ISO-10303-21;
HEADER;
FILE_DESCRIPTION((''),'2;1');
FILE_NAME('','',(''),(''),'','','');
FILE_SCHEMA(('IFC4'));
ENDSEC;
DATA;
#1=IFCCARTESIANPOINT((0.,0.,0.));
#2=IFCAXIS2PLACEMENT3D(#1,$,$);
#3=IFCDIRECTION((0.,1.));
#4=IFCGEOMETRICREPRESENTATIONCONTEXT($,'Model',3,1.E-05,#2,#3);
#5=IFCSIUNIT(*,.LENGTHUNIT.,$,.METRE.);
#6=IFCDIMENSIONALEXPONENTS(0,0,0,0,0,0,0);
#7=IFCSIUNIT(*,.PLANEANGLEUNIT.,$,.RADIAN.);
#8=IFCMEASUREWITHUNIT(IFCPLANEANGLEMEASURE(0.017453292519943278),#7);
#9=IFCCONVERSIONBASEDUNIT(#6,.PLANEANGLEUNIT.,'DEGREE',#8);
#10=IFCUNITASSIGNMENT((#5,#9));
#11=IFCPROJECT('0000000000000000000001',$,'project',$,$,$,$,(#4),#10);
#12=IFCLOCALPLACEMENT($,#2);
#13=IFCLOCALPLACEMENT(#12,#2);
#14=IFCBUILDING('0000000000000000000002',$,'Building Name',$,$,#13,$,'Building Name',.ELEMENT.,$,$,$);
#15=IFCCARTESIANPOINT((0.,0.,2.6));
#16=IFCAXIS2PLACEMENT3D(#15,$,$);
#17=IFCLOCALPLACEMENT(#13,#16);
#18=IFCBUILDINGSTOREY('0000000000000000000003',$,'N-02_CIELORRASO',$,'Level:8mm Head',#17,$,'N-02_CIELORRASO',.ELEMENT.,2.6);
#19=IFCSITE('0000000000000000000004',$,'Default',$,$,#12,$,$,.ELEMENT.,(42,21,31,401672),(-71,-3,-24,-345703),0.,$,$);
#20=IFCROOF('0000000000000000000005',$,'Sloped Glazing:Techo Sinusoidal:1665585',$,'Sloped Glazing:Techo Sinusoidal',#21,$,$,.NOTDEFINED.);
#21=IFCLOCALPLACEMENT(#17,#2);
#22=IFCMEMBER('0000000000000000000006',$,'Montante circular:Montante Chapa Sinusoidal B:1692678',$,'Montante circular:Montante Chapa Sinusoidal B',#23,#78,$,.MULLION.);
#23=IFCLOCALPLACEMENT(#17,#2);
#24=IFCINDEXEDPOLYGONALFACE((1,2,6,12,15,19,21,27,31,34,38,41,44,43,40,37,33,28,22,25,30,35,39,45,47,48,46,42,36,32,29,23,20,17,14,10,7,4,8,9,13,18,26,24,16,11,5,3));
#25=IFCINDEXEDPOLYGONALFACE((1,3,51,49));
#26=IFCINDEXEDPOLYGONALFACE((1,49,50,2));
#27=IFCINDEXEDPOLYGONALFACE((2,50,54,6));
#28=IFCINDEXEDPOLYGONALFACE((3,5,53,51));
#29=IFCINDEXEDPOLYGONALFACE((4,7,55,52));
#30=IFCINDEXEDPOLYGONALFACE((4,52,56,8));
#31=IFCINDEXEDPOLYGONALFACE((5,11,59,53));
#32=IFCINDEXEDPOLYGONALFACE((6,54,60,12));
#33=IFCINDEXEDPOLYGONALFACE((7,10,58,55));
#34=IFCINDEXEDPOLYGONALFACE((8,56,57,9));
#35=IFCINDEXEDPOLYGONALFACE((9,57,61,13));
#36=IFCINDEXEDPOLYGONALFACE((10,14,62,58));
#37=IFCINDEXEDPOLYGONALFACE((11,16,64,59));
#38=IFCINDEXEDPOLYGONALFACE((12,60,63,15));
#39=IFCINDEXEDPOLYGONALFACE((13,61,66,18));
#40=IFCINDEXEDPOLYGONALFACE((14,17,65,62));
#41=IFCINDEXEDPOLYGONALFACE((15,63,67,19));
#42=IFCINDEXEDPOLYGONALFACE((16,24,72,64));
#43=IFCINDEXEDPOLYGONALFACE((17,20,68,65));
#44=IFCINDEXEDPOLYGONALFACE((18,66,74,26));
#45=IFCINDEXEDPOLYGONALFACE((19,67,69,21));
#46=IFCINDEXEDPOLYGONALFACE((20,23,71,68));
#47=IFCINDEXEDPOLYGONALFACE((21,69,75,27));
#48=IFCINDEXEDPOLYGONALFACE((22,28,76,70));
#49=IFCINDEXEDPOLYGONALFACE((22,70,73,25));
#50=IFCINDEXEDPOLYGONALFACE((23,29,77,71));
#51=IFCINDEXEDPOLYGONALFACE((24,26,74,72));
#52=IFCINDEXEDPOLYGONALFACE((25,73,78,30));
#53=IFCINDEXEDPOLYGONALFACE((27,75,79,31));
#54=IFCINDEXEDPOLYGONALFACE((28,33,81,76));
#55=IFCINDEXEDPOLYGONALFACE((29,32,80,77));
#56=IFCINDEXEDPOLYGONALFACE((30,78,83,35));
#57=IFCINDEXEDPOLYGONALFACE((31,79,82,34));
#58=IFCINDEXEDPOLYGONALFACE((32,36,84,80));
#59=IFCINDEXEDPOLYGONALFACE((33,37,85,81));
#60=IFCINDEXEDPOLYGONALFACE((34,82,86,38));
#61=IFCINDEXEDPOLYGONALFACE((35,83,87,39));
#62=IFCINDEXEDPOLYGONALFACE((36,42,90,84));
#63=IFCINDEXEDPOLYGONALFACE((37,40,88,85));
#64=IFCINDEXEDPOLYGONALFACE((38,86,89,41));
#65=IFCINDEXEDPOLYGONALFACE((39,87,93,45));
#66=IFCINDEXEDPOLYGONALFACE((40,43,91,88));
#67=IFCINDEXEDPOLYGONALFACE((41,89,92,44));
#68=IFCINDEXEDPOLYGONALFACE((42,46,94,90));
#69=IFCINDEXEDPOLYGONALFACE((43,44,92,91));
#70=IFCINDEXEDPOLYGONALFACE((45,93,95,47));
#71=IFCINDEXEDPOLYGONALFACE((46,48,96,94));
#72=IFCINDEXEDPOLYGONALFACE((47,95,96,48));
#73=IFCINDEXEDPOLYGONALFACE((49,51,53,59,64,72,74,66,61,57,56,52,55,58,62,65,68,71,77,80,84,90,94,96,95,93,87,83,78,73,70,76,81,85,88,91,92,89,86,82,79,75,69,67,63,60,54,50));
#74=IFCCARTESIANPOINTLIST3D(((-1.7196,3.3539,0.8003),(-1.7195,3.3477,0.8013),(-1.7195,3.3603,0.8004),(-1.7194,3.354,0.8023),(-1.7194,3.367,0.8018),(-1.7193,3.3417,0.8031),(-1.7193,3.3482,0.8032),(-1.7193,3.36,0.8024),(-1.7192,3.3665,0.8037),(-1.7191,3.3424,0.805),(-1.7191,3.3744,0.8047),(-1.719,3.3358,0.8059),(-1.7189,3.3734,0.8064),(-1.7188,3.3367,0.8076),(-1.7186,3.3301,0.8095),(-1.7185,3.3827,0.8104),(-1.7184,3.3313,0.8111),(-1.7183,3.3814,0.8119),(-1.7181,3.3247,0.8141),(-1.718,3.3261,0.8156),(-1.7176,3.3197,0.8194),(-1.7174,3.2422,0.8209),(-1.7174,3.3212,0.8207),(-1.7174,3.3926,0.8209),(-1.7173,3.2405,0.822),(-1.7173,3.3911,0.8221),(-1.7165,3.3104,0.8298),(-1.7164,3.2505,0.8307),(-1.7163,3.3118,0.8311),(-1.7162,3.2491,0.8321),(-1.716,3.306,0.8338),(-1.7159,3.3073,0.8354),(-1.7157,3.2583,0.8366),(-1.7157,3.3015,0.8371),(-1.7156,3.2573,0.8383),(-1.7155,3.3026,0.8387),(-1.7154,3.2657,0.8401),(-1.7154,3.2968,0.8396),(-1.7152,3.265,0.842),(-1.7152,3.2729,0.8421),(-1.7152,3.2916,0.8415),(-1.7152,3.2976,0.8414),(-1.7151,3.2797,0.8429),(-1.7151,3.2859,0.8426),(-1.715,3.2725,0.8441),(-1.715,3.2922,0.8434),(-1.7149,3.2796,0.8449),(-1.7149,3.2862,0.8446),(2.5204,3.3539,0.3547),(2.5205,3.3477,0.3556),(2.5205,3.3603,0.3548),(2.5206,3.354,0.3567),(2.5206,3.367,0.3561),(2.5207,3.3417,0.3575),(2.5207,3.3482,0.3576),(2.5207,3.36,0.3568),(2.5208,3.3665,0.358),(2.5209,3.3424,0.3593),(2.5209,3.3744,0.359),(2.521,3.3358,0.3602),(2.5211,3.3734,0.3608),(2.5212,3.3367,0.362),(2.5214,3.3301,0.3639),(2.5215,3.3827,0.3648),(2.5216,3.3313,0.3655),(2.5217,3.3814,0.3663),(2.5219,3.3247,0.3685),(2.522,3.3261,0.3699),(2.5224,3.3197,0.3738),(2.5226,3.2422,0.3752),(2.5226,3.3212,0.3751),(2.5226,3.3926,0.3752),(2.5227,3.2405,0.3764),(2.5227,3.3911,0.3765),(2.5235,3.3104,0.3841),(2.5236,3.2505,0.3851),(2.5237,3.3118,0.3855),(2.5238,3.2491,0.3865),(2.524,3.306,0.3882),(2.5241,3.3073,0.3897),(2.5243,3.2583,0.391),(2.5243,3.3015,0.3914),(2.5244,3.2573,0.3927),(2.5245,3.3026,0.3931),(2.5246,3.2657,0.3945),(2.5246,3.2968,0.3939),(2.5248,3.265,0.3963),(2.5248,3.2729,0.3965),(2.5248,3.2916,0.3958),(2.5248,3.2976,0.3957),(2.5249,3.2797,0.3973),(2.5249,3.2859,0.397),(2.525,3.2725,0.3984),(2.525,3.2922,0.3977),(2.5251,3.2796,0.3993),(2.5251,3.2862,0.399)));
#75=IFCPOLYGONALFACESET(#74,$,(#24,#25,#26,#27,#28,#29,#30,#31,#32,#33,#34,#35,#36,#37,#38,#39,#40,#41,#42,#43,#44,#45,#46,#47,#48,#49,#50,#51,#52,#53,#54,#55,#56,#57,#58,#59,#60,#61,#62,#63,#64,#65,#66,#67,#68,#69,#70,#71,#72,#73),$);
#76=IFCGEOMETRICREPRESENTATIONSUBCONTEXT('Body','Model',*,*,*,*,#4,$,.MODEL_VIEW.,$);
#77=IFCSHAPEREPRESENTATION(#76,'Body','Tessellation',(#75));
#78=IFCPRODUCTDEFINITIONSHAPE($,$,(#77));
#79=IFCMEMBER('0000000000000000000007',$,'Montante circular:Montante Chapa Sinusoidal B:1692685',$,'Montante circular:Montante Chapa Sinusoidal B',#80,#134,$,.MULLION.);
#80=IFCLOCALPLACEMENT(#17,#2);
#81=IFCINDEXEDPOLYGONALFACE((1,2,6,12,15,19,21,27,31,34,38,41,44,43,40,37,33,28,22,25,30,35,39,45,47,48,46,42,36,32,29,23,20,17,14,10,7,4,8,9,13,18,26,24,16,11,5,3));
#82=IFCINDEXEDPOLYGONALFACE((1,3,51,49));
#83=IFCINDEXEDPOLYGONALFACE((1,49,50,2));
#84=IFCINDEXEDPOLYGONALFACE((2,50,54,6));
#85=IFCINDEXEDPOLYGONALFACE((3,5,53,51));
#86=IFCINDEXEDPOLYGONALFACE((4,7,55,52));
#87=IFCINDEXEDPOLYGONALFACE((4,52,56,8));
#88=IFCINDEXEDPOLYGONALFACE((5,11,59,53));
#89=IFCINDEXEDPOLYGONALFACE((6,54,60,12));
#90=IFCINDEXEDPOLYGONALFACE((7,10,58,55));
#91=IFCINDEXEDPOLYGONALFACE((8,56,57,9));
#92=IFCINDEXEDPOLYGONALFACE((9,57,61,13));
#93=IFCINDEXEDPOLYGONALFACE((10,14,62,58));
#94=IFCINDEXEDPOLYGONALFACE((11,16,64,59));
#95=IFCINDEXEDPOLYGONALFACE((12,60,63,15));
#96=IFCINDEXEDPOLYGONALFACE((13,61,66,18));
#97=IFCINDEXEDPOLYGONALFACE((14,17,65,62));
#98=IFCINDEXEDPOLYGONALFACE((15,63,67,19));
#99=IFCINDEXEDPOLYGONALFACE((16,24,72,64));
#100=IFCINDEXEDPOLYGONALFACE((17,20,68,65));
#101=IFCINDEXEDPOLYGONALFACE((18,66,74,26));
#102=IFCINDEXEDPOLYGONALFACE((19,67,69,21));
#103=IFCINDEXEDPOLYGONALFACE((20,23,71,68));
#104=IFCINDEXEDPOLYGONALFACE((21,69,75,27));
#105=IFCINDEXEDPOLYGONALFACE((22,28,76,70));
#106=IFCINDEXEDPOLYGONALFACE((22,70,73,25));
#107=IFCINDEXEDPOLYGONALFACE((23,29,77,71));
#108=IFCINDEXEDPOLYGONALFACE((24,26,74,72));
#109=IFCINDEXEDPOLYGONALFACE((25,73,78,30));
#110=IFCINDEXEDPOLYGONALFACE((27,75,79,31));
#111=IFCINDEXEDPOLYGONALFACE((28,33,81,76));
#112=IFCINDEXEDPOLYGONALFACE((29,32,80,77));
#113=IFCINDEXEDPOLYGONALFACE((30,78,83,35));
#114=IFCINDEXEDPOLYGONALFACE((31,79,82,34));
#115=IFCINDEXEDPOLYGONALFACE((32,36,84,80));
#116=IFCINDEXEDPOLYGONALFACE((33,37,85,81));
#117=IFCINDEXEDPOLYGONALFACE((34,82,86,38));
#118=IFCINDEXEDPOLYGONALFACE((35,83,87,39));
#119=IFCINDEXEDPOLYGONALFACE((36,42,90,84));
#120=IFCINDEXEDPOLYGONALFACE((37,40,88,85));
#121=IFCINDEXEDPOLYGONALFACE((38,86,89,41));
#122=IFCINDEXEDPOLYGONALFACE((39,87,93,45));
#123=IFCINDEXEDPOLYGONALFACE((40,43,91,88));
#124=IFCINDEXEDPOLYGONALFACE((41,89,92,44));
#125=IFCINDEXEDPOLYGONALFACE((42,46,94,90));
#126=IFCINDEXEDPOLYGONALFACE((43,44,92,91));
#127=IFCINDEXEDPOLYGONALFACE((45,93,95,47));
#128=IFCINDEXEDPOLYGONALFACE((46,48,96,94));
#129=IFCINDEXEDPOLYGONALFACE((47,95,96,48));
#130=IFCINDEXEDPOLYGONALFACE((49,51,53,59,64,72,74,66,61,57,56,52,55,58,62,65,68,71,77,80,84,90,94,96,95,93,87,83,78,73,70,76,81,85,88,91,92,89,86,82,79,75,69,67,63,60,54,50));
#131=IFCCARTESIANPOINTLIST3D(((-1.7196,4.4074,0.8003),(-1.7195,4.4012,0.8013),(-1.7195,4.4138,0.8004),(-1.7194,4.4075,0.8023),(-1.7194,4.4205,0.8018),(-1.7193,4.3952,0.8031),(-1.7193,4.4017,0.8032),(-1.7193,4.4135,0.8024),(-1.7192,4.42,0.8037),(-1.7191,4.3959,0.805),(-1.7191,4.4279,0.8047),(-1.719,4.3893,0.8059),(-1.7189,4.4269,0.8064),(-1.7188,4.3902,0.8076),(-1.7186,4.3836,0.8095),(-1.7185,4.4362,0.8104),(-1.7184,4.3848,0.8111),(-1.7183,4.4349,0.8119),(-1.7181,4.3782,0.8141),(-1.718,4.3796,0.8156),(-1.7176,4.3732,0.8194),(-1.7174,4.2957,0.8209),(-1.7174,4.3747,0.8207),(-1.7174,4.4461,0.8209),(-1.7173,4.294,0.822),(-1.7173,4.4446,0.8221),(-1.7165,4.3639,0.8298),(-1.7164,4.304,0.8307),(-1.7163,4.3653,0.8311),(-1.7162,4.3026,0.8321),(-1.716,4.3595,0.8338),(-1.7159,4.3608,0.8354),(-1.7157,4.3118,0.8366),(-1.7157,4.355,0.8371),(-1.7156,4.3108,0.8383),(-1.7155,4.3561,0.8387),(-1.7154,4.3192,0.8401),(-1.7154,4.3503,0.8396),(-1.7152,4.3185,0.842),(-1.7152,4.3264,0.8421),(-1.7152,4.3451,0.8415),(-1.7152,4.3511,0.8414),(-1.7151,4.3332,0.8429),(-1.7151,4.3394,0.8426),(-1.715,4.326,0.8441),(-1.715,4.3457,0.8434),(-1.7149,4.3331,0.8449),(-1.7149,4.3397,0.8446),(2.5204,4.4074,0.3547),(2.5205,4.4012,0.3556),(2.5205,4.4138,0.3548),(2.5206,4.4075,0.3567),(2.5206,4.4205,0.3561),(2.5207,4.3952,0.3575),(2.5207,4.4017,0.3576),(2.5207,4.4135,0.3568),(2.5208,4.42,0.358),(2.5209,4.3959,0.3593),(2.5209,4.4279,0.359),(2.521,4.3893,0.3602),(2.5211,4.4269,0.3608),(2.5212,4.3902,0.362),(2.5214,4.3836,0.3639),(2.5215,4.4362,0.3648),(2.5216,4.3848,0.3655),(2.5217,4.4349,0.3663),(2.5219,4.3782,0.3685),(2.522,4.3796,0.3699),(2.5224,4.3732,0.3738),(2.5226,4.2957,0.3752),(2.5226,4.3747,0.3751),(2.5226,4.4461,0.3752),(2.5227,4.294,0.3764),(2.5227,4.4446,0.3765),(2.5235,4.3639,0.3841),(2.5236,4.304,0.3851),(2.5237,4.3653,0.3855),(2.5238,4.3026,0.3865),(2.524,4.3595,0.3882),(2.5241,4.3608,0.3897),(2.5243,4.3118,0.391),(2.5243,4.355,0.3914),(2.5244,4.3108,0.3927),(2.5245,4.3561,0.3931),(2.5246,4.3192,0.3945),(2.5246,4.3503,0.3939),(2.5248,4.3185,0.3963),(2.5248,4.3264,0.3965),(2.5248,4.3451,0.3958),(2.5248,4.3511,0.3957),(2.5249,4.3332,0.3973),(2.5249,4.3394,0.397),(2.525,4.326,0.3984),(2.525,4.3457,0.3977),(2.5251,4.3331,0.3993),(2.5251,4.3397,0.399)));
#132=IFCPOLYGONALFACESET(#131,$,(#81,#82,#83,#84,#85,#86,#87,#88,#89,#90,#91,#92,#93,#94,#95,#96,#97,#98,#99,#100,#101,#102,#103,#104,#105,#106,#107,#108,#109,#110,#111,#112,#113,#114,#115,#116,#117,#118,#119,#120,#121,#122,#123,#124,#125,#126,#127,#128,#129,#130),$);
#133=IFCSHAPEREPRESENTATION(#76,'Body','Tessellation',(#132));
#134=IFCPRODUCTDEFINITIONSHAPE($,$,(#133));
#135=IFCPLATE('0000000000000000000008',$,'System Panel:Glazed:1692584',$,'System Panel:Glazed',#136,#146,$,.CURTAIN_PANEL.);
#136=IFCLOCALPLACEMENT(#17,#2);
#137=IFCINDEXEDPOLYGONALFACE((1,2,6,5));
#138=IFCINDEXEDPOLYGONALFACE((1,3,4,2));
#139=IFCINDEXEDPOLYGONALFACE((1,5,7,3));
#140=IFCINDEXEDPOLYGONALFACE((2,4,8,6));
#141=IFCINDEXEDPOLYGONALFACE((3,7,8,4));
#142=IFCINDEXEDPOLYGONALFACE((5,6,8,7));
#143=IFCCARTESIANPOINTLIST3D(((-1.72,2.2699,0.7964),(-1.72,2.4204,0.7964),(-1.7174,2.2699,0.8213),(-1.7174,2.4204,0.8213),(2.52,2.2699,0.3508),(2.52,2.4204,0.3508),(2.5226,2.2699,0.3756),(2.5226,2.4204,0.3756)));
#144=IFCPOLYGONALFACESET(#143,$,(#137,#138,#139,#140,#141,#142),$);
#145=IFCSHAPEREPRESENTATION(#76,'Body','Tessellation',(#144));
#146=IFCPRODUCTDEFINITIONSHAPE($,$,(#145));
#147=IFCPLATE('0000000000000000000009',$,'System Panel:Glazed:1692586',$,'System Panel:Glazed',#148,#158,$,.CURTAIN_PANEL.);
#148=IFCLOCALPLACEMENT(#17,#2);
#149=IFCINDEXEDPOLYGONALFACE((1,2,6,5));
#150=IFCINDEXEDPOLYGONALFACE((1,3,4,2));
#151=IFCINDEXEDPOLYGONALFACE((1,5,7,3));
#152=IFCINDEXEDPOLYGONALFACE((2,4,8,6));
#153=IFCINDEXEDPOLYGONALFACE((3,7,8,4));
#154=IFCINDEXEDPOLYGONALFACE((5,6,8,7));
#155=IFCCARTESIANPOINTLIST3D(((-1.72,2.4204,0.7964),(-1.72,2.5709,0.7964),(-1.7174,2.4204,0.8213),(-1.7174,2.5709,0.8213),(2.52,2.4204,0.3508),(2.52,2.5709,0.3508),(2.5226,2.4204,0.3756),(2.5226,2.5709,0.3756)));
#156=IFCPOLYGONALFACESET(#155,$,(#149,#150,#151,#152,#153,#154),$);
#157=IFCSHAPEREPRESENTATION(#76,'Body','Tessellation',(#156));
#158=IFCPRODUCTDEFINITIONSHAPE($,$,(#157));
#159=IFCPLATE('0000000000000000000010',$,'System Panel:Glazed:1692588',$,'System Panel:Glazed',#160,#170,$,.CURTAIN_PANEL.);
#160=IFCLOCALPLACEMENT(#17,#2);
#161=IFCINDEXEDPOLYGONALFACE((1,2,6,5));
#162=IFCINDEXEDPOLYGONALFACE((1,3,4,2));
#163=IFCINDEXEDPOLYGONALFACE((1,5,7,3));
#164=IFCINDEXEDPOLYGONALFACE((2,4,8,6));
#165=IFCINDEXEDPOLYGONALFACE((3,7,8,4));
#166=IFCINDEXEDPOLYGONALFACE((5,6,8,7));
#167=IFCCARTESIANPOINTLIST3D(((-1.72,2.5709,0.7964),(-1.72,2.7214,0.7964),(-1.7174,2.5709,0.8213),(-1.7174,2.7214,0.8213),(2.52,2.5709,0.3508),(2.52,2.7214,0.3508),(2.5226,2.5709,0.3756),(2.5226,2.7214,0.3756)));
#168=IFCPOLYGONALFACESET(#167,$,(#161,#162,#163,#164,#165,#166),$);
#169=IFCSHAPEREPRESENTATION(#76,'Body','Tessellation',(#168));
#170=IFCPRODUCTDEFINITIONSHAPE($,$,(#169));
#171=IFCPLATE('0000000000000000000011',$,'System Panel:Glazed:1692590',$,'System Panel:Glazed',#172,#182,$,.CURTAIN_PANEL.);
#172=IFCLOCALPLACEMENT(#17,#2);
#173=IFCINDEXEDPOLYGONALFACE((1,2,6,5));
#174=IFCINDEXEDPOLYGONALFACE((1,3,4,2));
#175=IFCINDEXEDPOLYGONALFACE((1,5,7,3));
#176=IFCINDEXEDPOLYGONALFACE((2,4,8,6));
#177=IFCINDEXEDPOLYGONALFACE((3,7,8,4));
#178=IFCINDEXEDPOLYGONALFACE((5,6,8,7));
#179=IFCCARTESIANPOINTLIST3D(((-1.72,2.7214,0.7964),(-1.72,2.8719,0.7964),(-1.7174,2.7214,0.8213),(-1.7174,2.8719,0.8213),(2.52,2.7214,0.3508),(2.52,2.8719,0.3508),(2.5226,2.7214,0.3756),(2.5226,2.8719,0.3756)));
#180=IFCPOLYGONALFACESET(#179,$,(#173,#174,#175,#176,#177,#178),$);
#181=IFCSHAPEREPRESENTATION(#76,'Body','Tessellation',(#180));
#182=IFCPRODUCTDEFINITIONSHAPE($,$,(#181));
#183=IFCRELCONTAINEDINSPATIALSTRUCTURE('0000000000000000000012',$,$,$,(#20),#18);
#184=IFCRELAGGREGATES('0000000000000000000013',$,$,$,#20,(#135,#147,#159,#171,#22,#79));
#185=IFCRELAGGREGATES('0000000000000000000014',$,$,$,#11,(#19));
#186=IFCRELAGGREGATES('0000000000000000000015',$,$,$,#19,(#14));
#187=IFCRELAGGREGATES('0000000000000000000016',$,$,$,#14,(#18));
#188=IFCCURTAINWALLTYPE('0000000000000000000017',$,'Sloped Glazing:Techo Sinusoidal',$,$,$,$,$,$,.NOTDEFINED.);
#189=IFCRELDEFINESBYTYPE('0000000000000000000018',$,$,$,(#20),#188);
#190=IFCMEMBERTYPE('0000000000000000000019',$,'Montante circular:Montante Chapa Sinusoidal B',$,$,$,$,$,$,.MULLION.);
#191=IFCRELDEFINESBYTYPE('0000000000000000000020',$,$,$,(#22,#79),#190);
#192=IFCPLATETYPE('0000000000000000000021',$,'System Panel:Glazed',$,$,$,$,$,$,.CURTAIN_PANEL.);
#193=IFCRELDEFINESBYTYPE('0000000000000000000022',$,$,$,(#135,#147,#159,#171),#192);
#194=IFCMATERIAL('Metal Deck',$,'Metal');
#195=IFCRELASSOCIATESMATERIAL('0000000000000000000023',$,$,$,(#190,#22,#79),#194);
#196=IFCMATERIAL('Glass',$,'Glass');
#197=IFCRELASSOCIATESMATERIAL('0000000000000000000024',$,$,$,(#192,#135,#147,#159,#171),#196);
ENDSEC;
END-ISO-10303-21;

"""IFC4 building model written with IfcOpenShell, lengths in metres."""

from ifc_helpers import new_model, entity, si_unit, converted_unit, direction, frame, origin, place, context, subcontext, project, spatial, indexed_curve, outline, extrude, source, transform, mapped, material, type_object, type_shapes, element, aggregate, save


model = new_model("IFC4")

# Units and contexts
model_context = context("Model", 3, precision=1e-05, world=origin(), true_north=direction((0.0, 1.0)))
body_context = subcontext(model_context, "Body", "Model", "MODEL_VIEW")
ifc_project = project(units=[si_unit("LENGTHUNIT", "METRE"), converted_unit("PLANEANGLEUNIT", "DEGREE", entity("IfcPlaneAngleMeasure", 0.017453292519943278), si_unit("PLANEANGLEUNIT", "RADIAN"), dimensions=[0, 0, 0, 0, 0, 0, 0])], contexts=[model_context])

# Site, building, storey
site_placement = place(None, origin())
site = spatial("IfcSite", under=ifc_project, at=site_placement, Name="Default", CompositionType="ELEMENT", RefLatitude=(42, 21, 31, 401672), RefLongitude=(-71, -3, -24, -345703), RefElevation=0.0)
building_placement = place(site_placement, origin())
building = spatial("IfcBuilding", under=site, at=building_placement, Name="Building Name", LongName="Building Name", CompositionType="ELEMENT")
storey_placement = place(building_placement, frame((0.0, 0.0, 2.6)))
storey = spatial("IfcBuildingStorey", under=building, at=storey_placement, Name="N-02_CIELORRASO", ObjectType="Level:8mm Head", LongName="N-02_CIELORRASO", CompositionType="ELEMENT", Elevation=2.6)

# Roof, members, plates
curtain_wall_type = type_object("IfcCurtainWallType", Name="Sloped Glazing:Techo Sinusoidal", PredefinedType="NOTDEFINED")
roof_placement = place(storey_placement, frame((0.0, 0.0, -2.6)))
roof = element("IfcRoof", 1, at=roof_placement, inside=storey, type_object=curtain_wall_type, Name="Sloped Glazing:Techo Sinusoidal:1665585", ObjectType="Sloped Glazing:Techo Sinusoidal", PredefinedType="NOTDEFINED")
ifc_material_1 = material(Name="Metal Deck", Category="Metal")
member_type = type_object("IfcMemberType", Name="Montante circular:Montante Chapa Sinusoidal B", PredefinedType="MULLION", material=ifc_material_1)
shared_shape_1 = source(origin(), body_context, "Body", "SweptSolid", [
    extrude(outline(indexed_curve([(0.0595, -0.0443), (0.0615, -0.0443), (0.0603, -0.031), (0.0572, -0.0213), (0.053, -0.0138), (0.0481, -0.0078), (0.0427, -0.003), (0.0372, 0.0005), (0.0315, 0.0029), (0.0259, 0.0044), (0.0203, 0.0051), (0.0146, 0.005), (0.0084, 0.0041), (-0.0053, 0.0009), (-0.0123, -0.0005), (-0.0191, -0.0012), (-0.0256, -0.001), (-0.0317, 0.0001), (-0.0375, 0.0019), (-0.0428, 0.0046), (-0.0477, 0.0081), (-0.0522, 0.0128), (-0.0563, 0.0191), (-0.0597, 0.0282), (-0.0617, 0.0421), (-0.0637, 0.042), (-0.0616, 0.0277), (-0.0581, 0.0182), (-0.0537, 0.0116), (-0.049, 0.0066), (-0.0438, 0.0028), (-0.0382, 0.0001), (-0.0322, -0.0019), (-0.0258, -0.003), (-0.019, -0.0032), (-0.012, -0.0025), (-0.0048, -0.0011), (0.0088, 0.0021), (0.0147, 0.003), (0.0202, 0.0031), (0.0255, 0.0024), (0.0309, 0.001), (0.0362, -0.0013), (0.0415, -0.0046), (0.0466, -0.0092), (0.0513, -0.0149), (0.0554, -0.0221), (0.0584, -0.0314), (0.0595, -0.0443)], self_intersect=False)), frame((-0.007, 0.0228, -4.2634), z_axis=(0.0, 0.0, 1.0), x_axis=(-0.819152, -0.573576, 0.0)), (0.0, 0.0, 1.0), 4.2634),
])
type_shapes(member_type, [shared_shape_1])
member_1_placement = place(roof_placement, frame((-1.7148, 3.3234, 3.4456), z_axis=(-0.994522, 0.0, 0.104528), x_axis=(0.0, 1.0, 0.0)))
member_1 = element("IfcMember", 2, at=member_1_placement, type_object=member_type, material=ifc_material_1, Name="Montante circular:Montante Chapa Sinusoidal B:1692678", ObjectType="Montante circular:Montante Chapa Sinusoidal B", PredefinedType="MULLION", context=body_context, shape_type="MappedRepresentation", body=[
    mapped(shared_shape_1, transform((0.0, 0.0, 0.0), scale=1.0)),
])
member_2_placement = place(roof_placement, frame((-1.7148, 4.3769, 3.4456), z_axis=(-0.994522, 0.0, 0.104528), x_axis=(0.0, 1.0, 0.0)))
member_2 = element("IfcMember", 3, at=member_2_placement, type_object=member_type, material=ifc_material_1, Name="Montante circular:Montante Chapa Sinusoidal B:1692685", ObjectType="Montante circular:Montante Chapa Sinusoidal B", PredefinedType="MULLION", context=body_context, shape_type="MappedRepresentation", body=[
    mapped(shared_shape_1, transform((0.0, 0.0, 0.0), scale=1.0)),
])
ifc_material_2 = material(Name="Glass", Category="Glass")
plate_type_1 = type_object("IfcPlateType", Name="System Panel:Glazed", PredefinedType="CURTAIN_PANEL", material=ifc_material_2)
shared_shape_2 = source(origin(), body_context, "Body", "SweptSolid", [
    extrude(outline(indexed_curve([(-0.0125, -0.0752), (0.0125, -0.0752), (0.0125, 0.0752), (-0.0125, 0.0752), (-0.0125, -0.0752)], self_intersect=False)), frame((0.0, 0.037, 0.0), z_axis=(0.0, 0.0, 1.0), x_axis=(0.0, 1.0, 0.0)), (0.0, 0.0, 1.0), 4.2634),
])
type_shapes(plate_type_1, [shared_shape_2])
plate_1_placement = place(roof_placement, frame((2.5252, 2.3451, 3.0), z_axis=(-0.994522, 0.0, 0.104528), x_axis=(0.0, 1.0, 0.0)))
plate_1 = element("IfcPlate", 4, at=plate_1_placement, type_object=plate_type_1, material=ifc_material_2, Name="System Panel:Glazed:1692584", ObjectType="System Panel:Glazed", PredefinedType="CURTAIN_PANEL", context=body_context, shape_type="MappedRepresentation", body=[
    mapped(shared_shape_2, transform((0.0, 0.0, 0.0), scale=1.0)),
])
plate_2_placement = place(roof_placement, frame((2.5252, 2.4956, 3.0), z_axis=(-0.994522, 0.0, 0.104528), x_axis=(0.0, 1.0, 0.0)))
plate_2 = element("IfcPlate", 5, at=plate_2_placement, type_object=plate_type_1, material=ifc_material_2, Name="System Panel:Glazed:1692586", ObjectType="System Panel:Glazed", PredefinedType="CURTAIN_PANEL", context=body_context, shape_type="MappedRepresentation", body=[
    mapped(shared_shape_2, transform((0.0, 0.0, 0.0), scale=1.0)),
])
plate_3_placement = place(roof_placement, frame((2.5252, 2.6461, 3.0), z_axis=(-0.994522, 0.0, 0.104528), x_axis=(0.0, 1.0, 0.0)))
plate_3 = element("IfcPlate", 6, at=plate_3_placement, type_object=plate_type_1, material=ifc_material_2, Name="System Panel:Glazed:1692588", ObjectType="System Panel:Glazed", PredefinedType="CURTAIN_PANEL", context=body_context, shape_type="MappedRepresentation", body=[
    mapped(shared_shape_2, transform((0.0, 0.0, 0.0), scale=1.0)),
])
plate_4_placement = place(roof_placement, frame((2.5252, 2.7966, 3.0), z_axis=(-0.994522, 0.0, 0.104528), x_axis=(0.0, 1.0, 0.0)))
plate_4 = element("IfcPlate", 7, at=plate_4_placement, type_object=plate_type_1, material=ifc_material_2, Name="System Panel:Glazed:1692590", ObjectType="System Panel:Glazed", PredefinedType="CURTAIN_PANEL", context=body_context, shape_type="MappedRepresentation", body=[
    mapped(shared_shape_2, transform((0.0, 0.0, 0.0), scale=1.0)),
])
aggregate(roof, [plate_1, plate_2, plate_3, plate_4, member_1, member_2])

save(model, "model.ifc")
